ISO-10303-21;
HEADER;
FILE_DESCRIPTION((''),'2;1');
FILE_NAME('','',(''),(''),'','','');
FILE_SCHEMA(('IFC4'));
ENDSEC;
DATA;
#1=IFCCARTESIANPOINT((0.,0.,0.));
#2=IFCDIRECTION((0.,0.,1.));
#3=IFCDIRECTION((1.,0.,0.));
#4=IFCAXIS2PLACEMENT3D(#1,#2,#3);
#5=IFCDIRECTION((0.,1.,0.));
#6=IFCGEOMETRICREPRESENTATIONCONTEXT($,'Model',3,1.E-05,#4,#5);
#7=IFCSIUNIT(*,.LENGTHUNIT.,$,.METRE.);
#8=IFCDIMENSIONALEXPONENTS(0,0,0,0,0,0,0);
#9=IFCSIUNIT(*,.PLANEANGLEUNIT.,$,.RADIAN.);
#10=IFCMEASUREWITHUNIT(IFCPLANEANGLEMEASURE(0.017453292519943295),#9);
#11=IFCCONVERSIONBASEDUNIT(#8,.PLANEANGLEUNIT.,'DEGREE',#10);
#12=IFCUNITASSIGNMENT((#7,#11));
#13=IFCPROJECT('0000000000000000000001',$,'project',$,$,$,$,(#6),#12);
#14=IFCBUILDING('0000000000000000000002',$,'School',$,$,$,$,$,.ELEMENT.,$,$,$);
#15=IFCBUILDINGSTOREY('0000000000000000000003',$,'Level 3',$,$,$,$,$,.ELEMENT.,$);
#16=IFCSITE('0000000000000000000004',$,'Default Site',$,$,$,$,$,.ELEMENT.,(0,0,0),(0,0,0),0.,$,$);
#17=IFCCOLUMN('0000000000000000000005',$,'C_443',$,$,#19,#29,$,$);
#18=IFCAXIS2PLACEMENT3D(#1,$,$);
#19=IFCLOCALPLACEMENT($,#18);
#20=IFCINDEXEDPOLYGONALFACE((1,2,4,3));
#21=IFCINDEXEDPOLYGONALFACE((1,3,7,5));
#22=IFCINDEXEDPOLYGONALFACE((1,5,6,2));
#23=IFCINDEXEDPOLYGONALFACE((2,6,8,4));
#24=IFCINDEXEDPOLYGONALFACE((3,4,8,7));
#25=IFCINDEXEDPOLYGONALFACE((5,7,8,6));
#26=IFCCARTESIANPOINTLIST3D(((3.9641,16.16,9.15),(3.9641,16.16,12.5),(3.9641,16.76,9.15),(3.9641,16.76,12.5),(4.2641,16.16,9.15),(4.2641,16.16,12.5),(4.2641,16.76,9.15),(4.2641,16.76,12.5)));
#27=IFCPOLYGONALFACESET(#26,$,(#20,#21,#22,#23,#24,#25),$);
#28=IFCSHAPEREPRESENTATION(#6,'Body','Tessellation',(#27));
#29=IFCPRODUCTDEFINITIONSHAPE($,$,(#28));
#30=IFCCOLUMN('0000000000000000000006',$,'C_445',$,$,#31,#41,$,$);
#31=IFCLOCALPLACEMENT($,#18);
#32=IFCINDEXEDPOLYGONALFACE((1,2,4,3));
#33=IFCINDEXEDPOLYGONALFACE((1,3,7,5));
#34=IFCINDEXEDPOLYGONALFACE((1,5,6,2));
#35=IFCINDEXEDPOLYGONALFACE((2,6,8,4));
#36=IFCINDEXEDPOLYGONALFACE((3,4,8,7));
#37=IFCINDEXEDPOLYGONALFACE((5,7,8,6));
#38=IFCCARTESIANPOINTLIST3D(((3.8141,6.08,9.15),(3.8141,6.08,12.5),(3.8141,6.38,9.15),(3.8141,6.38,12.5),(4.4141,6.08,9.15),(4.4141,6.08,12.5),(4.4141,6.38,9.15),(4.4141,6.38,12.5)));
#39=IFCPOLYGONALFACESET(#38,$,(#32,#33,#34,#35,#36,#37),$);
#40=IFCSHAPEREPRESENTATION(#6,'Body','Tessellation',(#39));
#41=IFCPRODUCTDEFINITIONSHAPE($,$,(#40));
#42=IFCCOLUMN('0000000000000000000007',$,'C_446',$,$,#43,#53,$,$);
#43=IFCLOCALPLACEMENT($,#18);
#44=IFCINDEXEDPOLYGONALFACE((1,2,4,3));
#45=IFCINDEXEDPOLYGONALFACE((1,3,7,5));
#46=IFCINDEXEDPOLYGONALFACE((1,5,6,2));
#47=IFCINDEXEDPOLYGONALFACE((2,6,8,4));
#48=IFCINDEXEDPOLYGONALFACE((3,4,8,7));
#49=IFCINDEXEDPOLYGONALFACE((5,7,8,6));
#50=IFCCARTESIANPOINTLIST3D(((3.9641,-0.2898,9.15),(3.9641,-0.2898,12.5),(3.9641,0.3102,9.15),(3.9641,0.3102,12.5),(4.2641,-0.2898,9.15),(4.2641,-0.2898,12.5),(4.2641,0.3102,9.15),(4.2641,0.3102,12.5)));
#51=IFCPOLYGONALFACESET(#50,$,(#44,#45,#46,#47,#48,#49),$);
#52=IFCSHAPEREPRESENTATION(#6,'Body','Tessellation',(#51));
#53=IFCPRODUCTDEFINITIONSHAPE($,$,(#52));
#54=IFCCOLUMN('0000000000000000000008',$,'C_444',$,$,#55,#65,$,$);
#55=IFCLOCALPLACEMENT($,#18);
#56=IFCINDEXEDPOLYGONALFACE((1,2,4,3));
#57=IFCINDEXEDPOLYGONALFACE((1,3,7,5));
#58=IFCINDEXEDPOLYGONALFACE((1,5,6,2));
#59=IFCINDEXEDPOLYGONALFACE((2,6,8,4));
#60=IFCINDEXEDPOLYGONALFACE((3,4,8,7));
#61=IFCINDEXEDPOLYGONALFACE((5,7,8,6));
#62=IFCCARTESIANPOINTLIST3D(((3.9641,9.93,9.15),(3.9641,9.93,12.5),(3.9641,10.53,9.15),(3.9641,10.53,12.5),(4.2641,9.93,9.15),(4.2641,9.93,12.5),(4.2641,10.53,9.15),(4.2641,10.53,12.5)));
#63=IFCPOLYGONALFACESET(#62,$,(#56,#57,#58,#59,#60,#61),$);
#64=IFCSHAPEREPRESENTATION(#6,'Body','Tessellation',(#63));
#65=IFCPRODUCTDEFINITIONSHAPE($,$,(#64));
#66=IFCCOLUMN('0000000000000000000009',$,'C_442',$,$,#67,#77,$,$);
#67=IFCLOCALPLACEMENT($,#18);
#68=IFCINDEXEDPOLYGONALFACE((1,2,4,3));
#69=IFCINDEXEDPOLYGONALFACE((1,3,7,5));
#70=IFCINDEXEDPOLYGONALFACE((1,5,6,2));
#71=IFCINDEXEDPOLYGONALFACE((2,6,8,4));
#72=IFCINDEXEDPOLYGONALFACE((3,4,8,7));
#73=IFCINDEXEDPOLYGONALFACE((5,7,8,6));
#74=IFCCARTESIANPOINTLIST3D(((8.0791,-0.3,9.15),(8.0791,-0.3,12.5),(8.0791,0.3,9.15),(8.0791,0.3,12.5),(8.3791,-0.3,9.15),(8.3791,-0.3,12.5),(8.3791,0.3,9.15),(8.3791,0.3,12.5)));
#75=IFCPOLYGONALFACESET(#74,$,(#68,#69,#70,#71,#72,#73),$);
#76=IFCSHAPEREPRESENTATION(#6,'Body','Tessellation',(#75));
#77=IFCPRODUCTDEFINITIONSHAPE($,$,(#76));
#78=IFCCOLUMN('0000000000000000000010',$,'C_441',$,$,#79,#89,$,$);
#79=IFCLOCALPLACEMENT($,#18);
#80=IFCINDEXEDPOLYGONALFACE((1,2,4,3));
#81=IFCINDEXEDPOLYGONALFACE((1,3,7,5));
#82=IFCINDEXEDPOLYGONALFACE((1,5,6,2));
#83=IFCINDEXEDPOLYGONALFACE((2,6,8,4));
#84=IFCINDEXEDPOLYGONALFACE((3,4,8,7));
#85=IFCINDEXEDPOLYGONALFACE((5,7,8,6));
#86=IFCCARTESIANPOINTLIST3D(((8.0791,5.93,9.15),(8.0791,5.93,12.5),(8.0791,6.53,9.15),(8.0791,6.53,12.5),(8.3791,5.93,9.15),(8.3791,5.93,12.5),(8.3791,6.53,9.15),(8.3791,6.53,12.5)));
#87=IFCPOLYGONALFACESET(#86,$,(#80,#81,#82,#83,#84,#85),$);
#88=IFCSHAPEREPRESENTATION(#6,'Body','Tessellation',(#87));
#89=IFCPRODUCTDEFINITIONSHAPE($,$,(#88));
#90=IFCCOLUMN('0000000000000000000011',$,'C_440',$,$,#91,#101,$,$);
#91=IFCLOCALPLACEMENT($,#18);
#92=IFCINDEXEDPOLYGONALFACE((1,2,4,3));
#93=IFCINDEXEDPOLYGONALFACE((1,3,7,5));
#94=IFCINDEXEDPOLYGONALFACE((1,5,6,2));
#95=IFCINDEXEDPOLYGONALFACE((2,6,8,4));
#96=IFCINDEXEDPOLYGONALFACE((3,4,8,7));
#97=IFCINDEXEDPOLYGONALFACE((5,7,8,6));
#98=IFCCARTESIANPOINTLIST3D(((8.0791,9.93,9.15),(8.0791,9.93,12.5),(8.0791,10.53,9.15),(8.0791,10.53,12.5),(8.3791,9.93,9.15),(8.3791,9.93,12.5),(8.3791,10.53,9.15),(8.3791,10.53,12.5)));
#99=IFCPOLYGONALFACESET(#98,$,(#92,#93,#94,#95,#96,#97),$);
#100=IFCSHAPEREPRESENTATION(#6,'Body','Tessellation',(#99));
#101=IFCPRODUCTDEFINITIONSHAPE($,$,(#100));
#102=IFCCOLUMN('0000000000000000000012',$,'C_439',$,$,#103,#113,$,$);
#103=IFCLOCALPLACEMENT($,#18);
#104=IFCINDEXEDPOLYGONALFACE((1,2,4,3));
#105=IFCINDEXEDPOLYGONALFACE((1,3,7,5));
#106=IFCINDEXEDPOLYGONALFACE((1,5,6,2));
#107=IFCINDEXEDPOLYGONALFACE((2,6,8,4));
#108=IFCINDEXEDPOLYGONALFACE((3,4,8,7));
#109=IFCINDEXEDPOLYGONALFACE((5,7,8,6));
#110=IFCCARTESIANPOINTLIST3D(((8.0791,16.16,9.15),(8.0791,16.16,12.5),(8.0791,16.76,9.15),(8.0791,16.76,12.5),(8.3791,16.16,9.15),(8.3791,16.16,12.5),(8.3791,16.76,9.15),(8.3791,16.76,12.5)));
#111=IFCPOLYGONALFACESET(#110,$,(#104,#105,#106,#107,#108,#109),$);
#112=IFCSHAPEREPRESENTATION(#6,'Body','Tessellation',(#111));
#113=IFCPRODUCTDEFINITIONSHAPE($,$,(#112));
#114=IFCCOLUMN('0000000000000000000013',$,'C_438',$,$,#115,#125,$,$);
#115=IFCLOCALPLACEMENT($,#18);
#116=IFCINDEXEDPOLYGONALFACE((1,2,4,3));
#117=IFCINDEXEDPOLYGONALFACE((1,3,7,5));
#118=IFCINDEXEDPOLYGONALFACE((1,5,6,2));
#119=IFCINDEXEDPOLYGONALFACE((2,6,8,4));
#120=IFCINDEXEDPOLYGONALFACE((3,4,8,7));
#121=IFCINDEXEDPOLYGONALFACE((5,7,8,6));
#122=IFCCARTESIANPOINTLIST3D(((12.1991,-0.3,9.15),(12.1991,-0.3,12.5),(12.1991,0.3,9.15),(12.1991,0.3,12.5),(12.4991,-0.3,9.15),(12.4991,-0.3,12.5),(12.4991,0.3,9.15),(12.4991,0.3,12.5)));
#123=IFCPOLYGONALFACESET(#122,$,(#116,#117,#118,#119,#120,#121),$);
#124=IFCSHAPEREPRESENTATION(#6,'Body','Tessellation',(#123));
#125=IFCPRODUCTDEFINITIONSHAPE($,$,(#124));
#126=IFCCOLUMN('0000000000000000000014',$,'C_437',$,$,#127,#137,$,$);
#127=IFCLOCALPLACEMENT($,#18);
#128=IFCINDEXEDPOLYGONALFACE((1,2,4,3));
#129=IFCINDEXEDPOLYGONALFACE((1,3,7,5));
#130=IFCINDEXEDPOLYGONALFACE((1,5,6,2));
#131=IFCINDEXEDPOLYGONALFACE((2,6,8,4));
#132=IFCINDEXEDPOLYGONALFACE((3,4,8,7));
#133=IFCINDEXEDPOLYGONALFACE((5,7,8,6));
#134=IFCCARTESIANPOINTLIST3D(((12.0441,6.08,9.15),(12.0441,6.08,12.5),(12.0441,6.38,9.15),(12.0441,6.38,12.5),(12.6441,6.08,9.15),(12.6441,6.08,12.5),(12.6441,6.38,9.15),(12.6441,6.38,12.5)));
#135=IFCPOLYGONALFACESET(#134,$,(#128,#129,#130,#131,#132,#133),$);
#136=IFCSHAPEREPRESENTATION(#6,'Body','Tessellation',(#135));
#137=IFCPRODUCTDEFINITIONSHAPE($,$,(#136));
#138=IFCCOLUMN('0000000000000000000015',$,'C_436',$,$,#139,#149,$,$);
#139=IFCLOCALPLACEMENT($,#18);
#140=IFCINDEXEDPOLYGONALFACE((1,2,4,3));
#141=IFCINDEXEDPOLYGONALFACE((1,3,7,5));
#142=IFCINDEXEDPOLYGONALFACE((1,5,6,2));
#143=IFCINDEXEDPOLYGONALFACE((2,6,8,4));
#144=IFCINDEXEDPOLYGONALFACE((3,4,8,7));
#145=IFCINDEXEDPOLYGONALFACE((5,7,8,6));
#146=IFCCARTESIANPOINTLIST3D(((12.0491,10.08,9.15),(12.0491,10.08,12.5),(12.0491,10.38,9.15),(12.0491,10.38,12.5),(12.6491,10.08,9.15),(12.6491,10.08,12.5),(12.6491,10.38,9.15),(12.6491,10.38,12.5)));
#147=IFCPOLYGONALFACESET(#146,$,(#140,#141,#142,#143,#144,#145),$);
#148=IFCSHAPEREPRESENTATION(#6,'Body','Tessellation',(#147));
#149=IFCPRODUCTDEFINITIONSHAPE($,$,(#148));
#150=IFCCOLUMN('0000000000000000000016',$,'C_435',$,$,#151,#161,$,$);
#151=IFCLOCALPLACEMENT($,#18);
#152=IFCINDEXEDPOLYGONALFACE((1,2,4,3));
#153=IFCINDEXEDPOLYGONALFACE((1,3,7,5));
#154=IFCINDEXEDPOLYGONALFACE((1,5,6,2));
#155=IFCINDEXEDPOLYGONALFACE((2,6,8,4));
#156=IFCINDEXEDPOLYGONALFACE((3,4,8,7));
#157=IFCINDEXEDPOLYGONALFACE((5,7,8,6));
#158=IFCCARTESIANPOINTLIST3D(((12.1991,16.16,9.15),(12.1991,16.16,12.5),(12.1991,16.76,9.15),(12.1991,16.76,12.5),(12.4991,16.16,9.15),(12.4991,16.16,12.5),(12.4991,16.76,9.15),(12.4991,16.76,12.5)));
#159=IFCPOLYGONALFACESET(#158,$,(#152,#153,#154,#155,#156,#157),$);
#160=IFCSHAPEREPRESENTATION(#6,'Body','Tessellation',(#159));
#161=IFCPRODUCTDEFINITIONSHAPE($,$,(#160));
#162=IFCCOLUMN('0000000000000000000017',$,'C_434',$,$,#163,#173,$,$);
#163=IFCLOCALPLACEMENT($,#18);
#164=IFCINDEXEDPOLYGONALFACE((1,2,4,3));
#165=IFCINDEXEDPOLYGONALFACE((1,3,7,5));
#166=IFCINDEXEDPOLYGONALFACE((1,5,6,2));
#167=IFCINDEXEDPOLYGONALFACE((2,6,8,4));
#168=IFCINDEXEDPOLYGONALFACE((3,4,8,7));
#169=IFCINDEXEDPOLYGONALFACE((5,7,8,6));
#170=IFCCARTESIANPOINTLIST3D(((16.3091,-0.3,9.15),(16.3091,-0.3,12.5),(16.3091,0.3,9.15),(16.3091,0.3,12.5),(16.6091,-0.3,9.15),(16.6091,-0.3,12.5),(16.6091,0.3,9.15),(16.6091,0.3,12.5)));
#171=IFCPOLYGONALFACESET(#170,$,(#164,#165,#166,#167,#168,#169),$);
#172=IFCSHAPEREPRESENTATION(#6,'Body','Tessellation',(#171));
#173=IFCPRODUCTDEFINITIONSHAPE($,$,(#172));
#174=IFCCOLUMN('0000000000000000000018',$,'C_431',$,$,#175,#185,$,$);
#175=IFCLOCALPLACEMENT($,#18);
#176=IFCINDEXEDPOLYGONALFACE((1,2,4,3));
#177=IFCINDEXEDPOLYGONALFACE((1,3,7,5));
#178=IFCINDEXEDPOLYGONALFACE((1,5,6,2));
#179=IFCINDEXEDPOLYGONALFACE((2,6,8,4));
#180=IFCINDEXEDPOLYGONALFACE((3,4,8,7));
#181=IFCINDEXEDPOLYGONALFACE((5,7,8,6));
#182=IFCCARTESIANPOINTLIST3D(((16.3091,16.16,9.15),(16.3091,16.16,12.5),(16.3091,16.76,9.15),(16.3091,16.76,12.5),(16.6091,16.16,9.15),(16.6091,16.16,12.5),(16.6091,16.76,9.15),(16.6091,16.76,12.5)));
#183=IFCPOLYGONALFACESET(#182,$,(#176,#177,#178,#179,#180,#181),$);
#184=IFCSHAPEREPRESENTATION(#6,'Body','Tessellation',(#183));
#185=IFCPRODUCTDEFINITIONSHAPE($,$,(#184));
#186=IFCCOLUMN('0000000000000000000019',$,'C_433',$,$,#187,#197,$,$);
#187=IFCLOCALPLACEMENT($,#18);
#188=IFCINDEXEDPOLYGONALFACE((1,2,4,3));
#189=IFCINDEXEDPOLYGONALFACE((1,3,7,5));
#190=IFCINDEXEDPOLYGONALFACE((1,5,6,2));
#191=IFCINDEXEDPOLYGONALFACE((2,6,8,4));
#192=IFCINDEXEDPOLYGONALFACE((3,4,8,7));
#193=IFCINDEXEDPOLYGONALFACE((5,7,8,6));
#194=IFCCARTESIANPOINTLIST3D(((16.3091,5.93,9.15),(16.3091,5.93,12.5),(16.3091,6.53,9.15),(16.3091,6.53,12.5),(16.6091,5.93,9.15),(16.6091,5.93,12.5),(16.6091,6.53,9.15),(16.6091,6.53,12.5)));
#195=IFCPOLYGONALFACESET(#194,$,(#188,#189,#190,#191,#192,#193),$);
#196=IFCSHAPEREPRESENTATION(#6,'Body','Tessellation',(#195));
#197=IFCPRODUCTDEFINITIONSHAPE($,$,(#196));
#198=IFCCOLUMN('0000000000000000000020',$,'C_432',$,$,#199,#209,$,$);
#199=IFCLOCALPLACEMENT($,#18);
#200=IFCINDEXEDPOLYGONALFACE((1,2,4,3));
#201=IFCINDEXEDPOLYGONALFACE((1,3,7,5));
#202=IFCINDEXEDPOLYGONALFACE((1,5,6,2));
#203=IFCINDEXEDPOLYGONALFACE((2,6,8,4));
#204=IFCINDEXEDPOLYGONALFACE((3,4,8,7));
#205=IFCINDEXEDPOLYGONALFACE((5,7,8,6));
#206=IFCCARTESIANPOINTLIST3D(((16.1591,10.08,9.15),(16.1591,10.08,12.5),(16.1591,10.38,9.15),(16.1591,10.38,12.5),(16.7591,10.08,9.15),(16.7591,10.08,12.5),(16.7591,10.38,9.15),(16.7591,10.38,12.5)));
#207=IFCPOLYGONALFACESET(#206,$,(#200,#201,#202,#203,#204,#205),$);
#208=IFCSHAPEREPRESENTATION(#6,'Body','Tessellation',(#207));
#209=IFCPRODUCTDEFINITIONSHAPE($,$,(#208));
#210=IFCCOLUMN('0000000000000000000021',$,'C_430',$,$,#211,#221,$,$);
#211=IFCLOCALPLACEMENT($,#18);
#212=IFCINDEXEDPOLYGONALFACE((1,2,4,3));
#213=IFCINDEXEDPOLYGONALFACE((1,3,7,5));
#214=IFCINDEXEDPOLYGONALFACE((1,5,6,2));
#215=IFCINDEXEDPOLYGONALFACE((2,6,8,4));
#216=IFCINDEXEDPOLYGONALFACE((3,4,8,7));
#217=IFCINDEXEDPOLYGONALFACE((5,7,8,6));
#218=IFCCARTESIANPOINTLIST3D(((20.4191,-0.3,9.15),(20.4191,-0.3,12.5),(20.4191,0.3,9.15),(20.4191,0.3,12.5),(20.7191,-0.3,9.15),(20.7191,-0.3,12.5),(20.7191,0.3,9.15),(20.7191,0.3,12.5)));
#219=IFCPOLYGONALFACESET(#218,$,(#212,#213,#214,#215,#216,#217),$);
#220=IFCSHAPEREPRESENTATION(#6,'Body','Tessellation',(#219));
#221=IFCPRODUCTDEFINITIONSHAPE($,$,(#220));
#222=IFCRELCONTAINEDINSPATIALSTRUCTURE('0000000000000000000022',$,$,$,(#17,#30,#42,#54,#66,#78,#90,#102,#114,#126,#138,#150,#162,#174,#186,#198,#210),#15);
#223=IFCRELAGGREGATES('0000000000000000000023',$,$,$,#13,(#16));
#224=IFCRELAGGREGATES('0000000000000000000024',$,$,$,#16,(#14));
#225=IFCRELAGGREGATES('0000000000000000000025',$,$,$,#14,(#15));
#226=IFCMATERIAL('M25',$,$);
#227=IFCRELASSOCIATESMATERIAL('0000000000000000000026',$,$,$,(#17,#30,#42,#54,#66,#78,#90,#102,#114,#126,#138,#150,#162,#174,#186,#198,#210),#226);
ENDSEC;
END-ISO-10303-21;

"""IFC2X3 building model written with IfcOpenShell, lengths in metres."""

from ifc_helpers import new_model, entity, si_unit, converted_unit, direction, frame, frame_2d, origin_with_axes, place, context, project, spatial, rectangle, extrude, material, element, save


model = new_model("IFC2X3")

# Units and contexts
model_context = context("Model", 3, precision=1e-05, world=origin_with_axes(), true_north=direction((0.0, 1.0, 0.0)))
ifc_project = project(units=[si_unit("LENGTHUNIT", "METRE"), converted_unit("PLANEANGLEUNIT", "DEGREE", entity("IfcPlaneAngleMeasure", 0.017453292519943295), si_unit("PLANEANGLEUNIT", "RADIAN"), dimensions=[0, 0, 0, 0, 0, 0, 0])], contexts=[model_context])

# Site, building, storey
site = spatial("IfcSite", under=ifc_project, Name="Default Site", CompositionType="ELEMENT", RefLatitude=(0, 0, 0), RefLongitude=(0, 0, 0), RefElevation=0.0)
building = spatial("IfcBuilding", under=site, Name="School", CompositionType="ELEMENT")
storey = spatial("IfcBuildingStorey", under=building, Name="Level 3", CompositionType="ELEMENT")

# Columns
ifc_material = material(Name="M25")
placement = place(None, origin_with_axes())
element("IfcColumn", 1, at=placement, inside=storey, material=ifc_material, Name="C_443", context=model_context, shape_type="SweptSolid", body=[
    extrude(rectangle(XDim=0.3, YDim=0.6, at=frame_2d((0.0, 0.0), x_axis=(1.0, 0.0, 0.0))), frame((4.1141, 16.46, 9.15), z_axis=(0.0, 0.0, 1.0), x_axis=(1.0, 0.0, 0.0)), (0.0, 0.0, 1.0), 3.35),
])
element("IfcColumn", 2, at=placement, inside=storey, material=ifc_material, Name="C_445", context=model_context, shape_type="SweptSolid", body=[
    extrude(rectangle(XDim=0.6, YDim=0.3, at=frame_2d((0.0, 0.0), x_axis=(1.0, 0.0, 0.0))), frame((4.1141, 6.23, 9.15), z_axis=(0.0, 0.0, 1.0), x_axis=(1.0, 0.0, 0.0)), (0.0, 0.0, 1.0), 3.35),
])
element("IfcColumn", 3, at=placement, inside=storey, material=ifc_material, Name="C_446", context=model_context, shape_type="SweptSolid", body=[
    extrude(rectangle(XDim=0.3, YDim=0.6, at=frame_2d((0.0, 0.0), x_axis=(1.0, 0.0, 0.0))), frame((4.1141, 0.0102, 9.15), z_axis=(0.0, 0.0, 1.0), x_axis=(1.0, 0.0, 0.0)), (0.0, 0.0, 1.0), 3.35),
])
element("IfcColumn", 4, at=placement, inside=storey, material=ifc_material, Name="C_444", context=model_context, shape_type="SweptSolid", body=[
    extrude(rectangle(XDim=0.3, YDim=0.6, at=frame_2d((0.0, 0.0), x_axis=(1.0, 0.0, 0.0))), frame((4.1141, 10.23, 9.15), z_axis=(0.0, 0.0, 1.0), x_axis=(1.0, 0.0, 0.0)), (0.0, 0.0, 1.0), 3.35),
])
element("IfcColumn", 5, at=placement, inside=storey, material=ifc_material, Name="C_442", context=model_context, shape_type="SweptSolid", body=[
    extrude(rectangle(XDim=0.3, YDim=0.6, at=frame_2d((0.0, 0.0), x_axis=(1.0, 0.0, 0.0))), frame((8.2291, 0.0, 9.15), z_axis=(0.0, 0.0, 1.0), x_axis=(1.0, 0.0, 0.0)), (0.0, 0.0, 1.0), 3.35),
])
element("IfcColumn", 6, at=placement, inside=storey, material=ifc_material, Name="C_441", context=model_context, shape_type="SweptSolid", body=[
    extrude(rectangle(XDim=0.3, YDim=0.6, at=frame_2d((0.0, 0.0), x_axis=(1.0, 0.0, 0.0))), frame((8.2291, 6.23, 9.15), z_axis=(0.0, 0.0, 1.0), x_axis=(1.0, 0.0, 0.0)), (0.0, 0.0, 1.0), 3.35),
])
element("IfcColumn", 7, at=placement, inside=storey, material=ifc_material, Name="C_440", context=model_context, shape_type="SweptSolid", body=[
    extrude(rectangle(XDim=0.3, YDim=0.6, at=frame_2d((0.0, 0.0), x_axis=(1.0, 0.0, 0.0))), frame((8.2291, 10.23, 9.15), z_axis=(0.0, 0.0, 1.0), x_axis=(1.0, 0.0, 0.0)), (0.0, 0.0, 1.0), 3.35),
])
element("IfcColumn", 8, at=placement, inside=storey, material=ifc_material, Name="C_439", context=model_context, shape_type="SweptSolid", body=[
    extrude(rectangle(XDim=0.3, YDim=0.6, at=frame_2d((0.0, 0.0), x_axis=(1.0, 0.0, 0.0))), frame((8.2291, 16.46, 9.15), z_axis=(0.0, 0.0, 1.0), x_axis=(1.0, 0.0, 0.0)), (0.0, 0.0, 1.0), 3.35),
])
element("IfcColumn", 9, at=placement, inside=storey, material=ifc_material, Name="C_438", context=model_context, shape_type="SweptSolid", body=[
    extrude(rectangle(XDim=0.3, YDim=0.6, at=frame_2d((0.0, 0.0), x_axis=(1.0, 0.0, 0.0))), frame((12.3491, 0.0, 9.15), z_axis=(0.0, 0.0, 1.0), x_axis=(1.0, 0.0, 0.0)), (0.0, 0.0, 1.0), 3.35),
])
element("IfcColumn", 10, at=placement, inside=storey, material=ifc_material, Name="C_437", context=model_context, shape_type="SweptSolid", body=[
    extrude(rectangle(XDim=0.6, YDim=0.3, at=frame_2d((0.0, 0.0), x_axis=(1.0, 0.0, 0.0))), frame((12.3441, 6.23, 9.15), z_axis=(0.0, 0.0, 1.0), x_axis=(1.0, 0.0, 0.0)), (0.0, 0.0, 1.0), 3.35),
])
element("IfcColumn", 11, at=placement, inside=storey, material=ifc_material, Name="C_436", context=model_context, shape_type="SweptSolid", body=[
    extrude(rectangle(XDim=0.6, YDim=0.3, at=frame_2d((0.0, 0.0), x_axis=(1.0, 0.0, 0.0))), frame((12.3491, 10.23, 9.15), z_axis=(0.0, 0.0, 1.0), x_axis=(1.0, 0.0, 0.0)), (0.0, 0.0, 1.0), 3.35),
])
element("IfcColumn", 12, at=placement, inside=storey, material=ifc_material, Name="C_435", context=model_context, shape_type="SweptSolid", body=[
    extrude(rectangle(XDim=0.3, YDim=0.6, at=frame_2d((0.0, 0.0), x_axis=(1.0, 0.0, 0.0))), frame((12.3491, 16.46, 9.15), z_axis=(0.0, 0.0, 1.0), x_axis=(1.0, 0.0, 0.0)), (0.0, 0.0, 1.0), 3.35),
])
element("IfcColumn", 13, at=placement, inside=storey, material=ifc_material, Name="C_434", context=model_context, shape_type="SweptSolid", body=[
    extrude(rectangle(XDim=0.3, YDim=0.6, at=frame_2d((0.0, 0.0), x_axis=(1.0, 0.0, 0.0))), frame((16.4591, 0.0, 9.15), z_axis=(0.0, 0.0, 1.0), x_axis=(1.0, 0.0, 0.0)), (0.0, 0.0, 1.0), 3.35),
])
element("IfcColumn", 14, at=placement, inside=storey, material=ifc_material, Name="C_431", context=model_context, shape_type="SweptSolid", body=[
    extrude(rectangle(XDim=0.3, YDim=0.6, at=frame_2d((0.0, 0.0), x_axis=(1.0, 0.0, 0.0))), frame((16.4591, 16.46, 9.15), z_axis=(0.0, 0.0, 1.0), x_axis=(1.0, 0.0, 0.0)), (0.0, 0.0, 1.0), 3.35),
])
element("IfcColumn", 15, at=placement, inside=storey, material=ifc_material, Name="C_433", context=model_context, shape_type="SweptSolid", body=[
    extrude(rectangle(XDim=0.3, YDim=0.6, at=frame_2d((0.0, 0.0), x_axis=(1.0, 0.0, 0.0))), frame((16.4591, 6.23, 9.15), z_axis=(0.0, 0.0, 1.0), x_axis=(1.0, 0.0, 0.0)), (0.0, 0.0, 1.0), 3.35),
])
element("IfcColumn", 16, at=placement, inside=storey, material=ifc_material, Name="C_432", context=model_context, shape_type="SweptSolid", body=[
    extrude(rectangle(XDim=0.6, YDim=0.3, at=frame_2d((0.0, 0.0), x_axis=(1.0, 0.0, 0.0))), frame((16.4591, 10.23, 9.15), z_axis=(0.0, 0.0, 1.0), x_axis=(1.0, 0.0, 0.0)), (0.0, 0.0, 1.0), 3.35),
])
element("IfcColumn", 17, at=placement, inside=storey, material=ifc_material, Name="C_430", context=model_context, shape_type="SweptSolid", body=[
    extrude(rectangle(XDim=0.3, YDim=0.6, at=frame_2d((0.0, 0.0), x_axis=(1.0, 0.0, 0.0))), frame((20.5691, 0.0, 9.15), z_axis=(0.0, 0.0, 1.0), x_axis=(1.0, 0.0, 0.0)), (0.0, 0.0, 1.0), 3.35),
])

save(model, "model.ifc")
